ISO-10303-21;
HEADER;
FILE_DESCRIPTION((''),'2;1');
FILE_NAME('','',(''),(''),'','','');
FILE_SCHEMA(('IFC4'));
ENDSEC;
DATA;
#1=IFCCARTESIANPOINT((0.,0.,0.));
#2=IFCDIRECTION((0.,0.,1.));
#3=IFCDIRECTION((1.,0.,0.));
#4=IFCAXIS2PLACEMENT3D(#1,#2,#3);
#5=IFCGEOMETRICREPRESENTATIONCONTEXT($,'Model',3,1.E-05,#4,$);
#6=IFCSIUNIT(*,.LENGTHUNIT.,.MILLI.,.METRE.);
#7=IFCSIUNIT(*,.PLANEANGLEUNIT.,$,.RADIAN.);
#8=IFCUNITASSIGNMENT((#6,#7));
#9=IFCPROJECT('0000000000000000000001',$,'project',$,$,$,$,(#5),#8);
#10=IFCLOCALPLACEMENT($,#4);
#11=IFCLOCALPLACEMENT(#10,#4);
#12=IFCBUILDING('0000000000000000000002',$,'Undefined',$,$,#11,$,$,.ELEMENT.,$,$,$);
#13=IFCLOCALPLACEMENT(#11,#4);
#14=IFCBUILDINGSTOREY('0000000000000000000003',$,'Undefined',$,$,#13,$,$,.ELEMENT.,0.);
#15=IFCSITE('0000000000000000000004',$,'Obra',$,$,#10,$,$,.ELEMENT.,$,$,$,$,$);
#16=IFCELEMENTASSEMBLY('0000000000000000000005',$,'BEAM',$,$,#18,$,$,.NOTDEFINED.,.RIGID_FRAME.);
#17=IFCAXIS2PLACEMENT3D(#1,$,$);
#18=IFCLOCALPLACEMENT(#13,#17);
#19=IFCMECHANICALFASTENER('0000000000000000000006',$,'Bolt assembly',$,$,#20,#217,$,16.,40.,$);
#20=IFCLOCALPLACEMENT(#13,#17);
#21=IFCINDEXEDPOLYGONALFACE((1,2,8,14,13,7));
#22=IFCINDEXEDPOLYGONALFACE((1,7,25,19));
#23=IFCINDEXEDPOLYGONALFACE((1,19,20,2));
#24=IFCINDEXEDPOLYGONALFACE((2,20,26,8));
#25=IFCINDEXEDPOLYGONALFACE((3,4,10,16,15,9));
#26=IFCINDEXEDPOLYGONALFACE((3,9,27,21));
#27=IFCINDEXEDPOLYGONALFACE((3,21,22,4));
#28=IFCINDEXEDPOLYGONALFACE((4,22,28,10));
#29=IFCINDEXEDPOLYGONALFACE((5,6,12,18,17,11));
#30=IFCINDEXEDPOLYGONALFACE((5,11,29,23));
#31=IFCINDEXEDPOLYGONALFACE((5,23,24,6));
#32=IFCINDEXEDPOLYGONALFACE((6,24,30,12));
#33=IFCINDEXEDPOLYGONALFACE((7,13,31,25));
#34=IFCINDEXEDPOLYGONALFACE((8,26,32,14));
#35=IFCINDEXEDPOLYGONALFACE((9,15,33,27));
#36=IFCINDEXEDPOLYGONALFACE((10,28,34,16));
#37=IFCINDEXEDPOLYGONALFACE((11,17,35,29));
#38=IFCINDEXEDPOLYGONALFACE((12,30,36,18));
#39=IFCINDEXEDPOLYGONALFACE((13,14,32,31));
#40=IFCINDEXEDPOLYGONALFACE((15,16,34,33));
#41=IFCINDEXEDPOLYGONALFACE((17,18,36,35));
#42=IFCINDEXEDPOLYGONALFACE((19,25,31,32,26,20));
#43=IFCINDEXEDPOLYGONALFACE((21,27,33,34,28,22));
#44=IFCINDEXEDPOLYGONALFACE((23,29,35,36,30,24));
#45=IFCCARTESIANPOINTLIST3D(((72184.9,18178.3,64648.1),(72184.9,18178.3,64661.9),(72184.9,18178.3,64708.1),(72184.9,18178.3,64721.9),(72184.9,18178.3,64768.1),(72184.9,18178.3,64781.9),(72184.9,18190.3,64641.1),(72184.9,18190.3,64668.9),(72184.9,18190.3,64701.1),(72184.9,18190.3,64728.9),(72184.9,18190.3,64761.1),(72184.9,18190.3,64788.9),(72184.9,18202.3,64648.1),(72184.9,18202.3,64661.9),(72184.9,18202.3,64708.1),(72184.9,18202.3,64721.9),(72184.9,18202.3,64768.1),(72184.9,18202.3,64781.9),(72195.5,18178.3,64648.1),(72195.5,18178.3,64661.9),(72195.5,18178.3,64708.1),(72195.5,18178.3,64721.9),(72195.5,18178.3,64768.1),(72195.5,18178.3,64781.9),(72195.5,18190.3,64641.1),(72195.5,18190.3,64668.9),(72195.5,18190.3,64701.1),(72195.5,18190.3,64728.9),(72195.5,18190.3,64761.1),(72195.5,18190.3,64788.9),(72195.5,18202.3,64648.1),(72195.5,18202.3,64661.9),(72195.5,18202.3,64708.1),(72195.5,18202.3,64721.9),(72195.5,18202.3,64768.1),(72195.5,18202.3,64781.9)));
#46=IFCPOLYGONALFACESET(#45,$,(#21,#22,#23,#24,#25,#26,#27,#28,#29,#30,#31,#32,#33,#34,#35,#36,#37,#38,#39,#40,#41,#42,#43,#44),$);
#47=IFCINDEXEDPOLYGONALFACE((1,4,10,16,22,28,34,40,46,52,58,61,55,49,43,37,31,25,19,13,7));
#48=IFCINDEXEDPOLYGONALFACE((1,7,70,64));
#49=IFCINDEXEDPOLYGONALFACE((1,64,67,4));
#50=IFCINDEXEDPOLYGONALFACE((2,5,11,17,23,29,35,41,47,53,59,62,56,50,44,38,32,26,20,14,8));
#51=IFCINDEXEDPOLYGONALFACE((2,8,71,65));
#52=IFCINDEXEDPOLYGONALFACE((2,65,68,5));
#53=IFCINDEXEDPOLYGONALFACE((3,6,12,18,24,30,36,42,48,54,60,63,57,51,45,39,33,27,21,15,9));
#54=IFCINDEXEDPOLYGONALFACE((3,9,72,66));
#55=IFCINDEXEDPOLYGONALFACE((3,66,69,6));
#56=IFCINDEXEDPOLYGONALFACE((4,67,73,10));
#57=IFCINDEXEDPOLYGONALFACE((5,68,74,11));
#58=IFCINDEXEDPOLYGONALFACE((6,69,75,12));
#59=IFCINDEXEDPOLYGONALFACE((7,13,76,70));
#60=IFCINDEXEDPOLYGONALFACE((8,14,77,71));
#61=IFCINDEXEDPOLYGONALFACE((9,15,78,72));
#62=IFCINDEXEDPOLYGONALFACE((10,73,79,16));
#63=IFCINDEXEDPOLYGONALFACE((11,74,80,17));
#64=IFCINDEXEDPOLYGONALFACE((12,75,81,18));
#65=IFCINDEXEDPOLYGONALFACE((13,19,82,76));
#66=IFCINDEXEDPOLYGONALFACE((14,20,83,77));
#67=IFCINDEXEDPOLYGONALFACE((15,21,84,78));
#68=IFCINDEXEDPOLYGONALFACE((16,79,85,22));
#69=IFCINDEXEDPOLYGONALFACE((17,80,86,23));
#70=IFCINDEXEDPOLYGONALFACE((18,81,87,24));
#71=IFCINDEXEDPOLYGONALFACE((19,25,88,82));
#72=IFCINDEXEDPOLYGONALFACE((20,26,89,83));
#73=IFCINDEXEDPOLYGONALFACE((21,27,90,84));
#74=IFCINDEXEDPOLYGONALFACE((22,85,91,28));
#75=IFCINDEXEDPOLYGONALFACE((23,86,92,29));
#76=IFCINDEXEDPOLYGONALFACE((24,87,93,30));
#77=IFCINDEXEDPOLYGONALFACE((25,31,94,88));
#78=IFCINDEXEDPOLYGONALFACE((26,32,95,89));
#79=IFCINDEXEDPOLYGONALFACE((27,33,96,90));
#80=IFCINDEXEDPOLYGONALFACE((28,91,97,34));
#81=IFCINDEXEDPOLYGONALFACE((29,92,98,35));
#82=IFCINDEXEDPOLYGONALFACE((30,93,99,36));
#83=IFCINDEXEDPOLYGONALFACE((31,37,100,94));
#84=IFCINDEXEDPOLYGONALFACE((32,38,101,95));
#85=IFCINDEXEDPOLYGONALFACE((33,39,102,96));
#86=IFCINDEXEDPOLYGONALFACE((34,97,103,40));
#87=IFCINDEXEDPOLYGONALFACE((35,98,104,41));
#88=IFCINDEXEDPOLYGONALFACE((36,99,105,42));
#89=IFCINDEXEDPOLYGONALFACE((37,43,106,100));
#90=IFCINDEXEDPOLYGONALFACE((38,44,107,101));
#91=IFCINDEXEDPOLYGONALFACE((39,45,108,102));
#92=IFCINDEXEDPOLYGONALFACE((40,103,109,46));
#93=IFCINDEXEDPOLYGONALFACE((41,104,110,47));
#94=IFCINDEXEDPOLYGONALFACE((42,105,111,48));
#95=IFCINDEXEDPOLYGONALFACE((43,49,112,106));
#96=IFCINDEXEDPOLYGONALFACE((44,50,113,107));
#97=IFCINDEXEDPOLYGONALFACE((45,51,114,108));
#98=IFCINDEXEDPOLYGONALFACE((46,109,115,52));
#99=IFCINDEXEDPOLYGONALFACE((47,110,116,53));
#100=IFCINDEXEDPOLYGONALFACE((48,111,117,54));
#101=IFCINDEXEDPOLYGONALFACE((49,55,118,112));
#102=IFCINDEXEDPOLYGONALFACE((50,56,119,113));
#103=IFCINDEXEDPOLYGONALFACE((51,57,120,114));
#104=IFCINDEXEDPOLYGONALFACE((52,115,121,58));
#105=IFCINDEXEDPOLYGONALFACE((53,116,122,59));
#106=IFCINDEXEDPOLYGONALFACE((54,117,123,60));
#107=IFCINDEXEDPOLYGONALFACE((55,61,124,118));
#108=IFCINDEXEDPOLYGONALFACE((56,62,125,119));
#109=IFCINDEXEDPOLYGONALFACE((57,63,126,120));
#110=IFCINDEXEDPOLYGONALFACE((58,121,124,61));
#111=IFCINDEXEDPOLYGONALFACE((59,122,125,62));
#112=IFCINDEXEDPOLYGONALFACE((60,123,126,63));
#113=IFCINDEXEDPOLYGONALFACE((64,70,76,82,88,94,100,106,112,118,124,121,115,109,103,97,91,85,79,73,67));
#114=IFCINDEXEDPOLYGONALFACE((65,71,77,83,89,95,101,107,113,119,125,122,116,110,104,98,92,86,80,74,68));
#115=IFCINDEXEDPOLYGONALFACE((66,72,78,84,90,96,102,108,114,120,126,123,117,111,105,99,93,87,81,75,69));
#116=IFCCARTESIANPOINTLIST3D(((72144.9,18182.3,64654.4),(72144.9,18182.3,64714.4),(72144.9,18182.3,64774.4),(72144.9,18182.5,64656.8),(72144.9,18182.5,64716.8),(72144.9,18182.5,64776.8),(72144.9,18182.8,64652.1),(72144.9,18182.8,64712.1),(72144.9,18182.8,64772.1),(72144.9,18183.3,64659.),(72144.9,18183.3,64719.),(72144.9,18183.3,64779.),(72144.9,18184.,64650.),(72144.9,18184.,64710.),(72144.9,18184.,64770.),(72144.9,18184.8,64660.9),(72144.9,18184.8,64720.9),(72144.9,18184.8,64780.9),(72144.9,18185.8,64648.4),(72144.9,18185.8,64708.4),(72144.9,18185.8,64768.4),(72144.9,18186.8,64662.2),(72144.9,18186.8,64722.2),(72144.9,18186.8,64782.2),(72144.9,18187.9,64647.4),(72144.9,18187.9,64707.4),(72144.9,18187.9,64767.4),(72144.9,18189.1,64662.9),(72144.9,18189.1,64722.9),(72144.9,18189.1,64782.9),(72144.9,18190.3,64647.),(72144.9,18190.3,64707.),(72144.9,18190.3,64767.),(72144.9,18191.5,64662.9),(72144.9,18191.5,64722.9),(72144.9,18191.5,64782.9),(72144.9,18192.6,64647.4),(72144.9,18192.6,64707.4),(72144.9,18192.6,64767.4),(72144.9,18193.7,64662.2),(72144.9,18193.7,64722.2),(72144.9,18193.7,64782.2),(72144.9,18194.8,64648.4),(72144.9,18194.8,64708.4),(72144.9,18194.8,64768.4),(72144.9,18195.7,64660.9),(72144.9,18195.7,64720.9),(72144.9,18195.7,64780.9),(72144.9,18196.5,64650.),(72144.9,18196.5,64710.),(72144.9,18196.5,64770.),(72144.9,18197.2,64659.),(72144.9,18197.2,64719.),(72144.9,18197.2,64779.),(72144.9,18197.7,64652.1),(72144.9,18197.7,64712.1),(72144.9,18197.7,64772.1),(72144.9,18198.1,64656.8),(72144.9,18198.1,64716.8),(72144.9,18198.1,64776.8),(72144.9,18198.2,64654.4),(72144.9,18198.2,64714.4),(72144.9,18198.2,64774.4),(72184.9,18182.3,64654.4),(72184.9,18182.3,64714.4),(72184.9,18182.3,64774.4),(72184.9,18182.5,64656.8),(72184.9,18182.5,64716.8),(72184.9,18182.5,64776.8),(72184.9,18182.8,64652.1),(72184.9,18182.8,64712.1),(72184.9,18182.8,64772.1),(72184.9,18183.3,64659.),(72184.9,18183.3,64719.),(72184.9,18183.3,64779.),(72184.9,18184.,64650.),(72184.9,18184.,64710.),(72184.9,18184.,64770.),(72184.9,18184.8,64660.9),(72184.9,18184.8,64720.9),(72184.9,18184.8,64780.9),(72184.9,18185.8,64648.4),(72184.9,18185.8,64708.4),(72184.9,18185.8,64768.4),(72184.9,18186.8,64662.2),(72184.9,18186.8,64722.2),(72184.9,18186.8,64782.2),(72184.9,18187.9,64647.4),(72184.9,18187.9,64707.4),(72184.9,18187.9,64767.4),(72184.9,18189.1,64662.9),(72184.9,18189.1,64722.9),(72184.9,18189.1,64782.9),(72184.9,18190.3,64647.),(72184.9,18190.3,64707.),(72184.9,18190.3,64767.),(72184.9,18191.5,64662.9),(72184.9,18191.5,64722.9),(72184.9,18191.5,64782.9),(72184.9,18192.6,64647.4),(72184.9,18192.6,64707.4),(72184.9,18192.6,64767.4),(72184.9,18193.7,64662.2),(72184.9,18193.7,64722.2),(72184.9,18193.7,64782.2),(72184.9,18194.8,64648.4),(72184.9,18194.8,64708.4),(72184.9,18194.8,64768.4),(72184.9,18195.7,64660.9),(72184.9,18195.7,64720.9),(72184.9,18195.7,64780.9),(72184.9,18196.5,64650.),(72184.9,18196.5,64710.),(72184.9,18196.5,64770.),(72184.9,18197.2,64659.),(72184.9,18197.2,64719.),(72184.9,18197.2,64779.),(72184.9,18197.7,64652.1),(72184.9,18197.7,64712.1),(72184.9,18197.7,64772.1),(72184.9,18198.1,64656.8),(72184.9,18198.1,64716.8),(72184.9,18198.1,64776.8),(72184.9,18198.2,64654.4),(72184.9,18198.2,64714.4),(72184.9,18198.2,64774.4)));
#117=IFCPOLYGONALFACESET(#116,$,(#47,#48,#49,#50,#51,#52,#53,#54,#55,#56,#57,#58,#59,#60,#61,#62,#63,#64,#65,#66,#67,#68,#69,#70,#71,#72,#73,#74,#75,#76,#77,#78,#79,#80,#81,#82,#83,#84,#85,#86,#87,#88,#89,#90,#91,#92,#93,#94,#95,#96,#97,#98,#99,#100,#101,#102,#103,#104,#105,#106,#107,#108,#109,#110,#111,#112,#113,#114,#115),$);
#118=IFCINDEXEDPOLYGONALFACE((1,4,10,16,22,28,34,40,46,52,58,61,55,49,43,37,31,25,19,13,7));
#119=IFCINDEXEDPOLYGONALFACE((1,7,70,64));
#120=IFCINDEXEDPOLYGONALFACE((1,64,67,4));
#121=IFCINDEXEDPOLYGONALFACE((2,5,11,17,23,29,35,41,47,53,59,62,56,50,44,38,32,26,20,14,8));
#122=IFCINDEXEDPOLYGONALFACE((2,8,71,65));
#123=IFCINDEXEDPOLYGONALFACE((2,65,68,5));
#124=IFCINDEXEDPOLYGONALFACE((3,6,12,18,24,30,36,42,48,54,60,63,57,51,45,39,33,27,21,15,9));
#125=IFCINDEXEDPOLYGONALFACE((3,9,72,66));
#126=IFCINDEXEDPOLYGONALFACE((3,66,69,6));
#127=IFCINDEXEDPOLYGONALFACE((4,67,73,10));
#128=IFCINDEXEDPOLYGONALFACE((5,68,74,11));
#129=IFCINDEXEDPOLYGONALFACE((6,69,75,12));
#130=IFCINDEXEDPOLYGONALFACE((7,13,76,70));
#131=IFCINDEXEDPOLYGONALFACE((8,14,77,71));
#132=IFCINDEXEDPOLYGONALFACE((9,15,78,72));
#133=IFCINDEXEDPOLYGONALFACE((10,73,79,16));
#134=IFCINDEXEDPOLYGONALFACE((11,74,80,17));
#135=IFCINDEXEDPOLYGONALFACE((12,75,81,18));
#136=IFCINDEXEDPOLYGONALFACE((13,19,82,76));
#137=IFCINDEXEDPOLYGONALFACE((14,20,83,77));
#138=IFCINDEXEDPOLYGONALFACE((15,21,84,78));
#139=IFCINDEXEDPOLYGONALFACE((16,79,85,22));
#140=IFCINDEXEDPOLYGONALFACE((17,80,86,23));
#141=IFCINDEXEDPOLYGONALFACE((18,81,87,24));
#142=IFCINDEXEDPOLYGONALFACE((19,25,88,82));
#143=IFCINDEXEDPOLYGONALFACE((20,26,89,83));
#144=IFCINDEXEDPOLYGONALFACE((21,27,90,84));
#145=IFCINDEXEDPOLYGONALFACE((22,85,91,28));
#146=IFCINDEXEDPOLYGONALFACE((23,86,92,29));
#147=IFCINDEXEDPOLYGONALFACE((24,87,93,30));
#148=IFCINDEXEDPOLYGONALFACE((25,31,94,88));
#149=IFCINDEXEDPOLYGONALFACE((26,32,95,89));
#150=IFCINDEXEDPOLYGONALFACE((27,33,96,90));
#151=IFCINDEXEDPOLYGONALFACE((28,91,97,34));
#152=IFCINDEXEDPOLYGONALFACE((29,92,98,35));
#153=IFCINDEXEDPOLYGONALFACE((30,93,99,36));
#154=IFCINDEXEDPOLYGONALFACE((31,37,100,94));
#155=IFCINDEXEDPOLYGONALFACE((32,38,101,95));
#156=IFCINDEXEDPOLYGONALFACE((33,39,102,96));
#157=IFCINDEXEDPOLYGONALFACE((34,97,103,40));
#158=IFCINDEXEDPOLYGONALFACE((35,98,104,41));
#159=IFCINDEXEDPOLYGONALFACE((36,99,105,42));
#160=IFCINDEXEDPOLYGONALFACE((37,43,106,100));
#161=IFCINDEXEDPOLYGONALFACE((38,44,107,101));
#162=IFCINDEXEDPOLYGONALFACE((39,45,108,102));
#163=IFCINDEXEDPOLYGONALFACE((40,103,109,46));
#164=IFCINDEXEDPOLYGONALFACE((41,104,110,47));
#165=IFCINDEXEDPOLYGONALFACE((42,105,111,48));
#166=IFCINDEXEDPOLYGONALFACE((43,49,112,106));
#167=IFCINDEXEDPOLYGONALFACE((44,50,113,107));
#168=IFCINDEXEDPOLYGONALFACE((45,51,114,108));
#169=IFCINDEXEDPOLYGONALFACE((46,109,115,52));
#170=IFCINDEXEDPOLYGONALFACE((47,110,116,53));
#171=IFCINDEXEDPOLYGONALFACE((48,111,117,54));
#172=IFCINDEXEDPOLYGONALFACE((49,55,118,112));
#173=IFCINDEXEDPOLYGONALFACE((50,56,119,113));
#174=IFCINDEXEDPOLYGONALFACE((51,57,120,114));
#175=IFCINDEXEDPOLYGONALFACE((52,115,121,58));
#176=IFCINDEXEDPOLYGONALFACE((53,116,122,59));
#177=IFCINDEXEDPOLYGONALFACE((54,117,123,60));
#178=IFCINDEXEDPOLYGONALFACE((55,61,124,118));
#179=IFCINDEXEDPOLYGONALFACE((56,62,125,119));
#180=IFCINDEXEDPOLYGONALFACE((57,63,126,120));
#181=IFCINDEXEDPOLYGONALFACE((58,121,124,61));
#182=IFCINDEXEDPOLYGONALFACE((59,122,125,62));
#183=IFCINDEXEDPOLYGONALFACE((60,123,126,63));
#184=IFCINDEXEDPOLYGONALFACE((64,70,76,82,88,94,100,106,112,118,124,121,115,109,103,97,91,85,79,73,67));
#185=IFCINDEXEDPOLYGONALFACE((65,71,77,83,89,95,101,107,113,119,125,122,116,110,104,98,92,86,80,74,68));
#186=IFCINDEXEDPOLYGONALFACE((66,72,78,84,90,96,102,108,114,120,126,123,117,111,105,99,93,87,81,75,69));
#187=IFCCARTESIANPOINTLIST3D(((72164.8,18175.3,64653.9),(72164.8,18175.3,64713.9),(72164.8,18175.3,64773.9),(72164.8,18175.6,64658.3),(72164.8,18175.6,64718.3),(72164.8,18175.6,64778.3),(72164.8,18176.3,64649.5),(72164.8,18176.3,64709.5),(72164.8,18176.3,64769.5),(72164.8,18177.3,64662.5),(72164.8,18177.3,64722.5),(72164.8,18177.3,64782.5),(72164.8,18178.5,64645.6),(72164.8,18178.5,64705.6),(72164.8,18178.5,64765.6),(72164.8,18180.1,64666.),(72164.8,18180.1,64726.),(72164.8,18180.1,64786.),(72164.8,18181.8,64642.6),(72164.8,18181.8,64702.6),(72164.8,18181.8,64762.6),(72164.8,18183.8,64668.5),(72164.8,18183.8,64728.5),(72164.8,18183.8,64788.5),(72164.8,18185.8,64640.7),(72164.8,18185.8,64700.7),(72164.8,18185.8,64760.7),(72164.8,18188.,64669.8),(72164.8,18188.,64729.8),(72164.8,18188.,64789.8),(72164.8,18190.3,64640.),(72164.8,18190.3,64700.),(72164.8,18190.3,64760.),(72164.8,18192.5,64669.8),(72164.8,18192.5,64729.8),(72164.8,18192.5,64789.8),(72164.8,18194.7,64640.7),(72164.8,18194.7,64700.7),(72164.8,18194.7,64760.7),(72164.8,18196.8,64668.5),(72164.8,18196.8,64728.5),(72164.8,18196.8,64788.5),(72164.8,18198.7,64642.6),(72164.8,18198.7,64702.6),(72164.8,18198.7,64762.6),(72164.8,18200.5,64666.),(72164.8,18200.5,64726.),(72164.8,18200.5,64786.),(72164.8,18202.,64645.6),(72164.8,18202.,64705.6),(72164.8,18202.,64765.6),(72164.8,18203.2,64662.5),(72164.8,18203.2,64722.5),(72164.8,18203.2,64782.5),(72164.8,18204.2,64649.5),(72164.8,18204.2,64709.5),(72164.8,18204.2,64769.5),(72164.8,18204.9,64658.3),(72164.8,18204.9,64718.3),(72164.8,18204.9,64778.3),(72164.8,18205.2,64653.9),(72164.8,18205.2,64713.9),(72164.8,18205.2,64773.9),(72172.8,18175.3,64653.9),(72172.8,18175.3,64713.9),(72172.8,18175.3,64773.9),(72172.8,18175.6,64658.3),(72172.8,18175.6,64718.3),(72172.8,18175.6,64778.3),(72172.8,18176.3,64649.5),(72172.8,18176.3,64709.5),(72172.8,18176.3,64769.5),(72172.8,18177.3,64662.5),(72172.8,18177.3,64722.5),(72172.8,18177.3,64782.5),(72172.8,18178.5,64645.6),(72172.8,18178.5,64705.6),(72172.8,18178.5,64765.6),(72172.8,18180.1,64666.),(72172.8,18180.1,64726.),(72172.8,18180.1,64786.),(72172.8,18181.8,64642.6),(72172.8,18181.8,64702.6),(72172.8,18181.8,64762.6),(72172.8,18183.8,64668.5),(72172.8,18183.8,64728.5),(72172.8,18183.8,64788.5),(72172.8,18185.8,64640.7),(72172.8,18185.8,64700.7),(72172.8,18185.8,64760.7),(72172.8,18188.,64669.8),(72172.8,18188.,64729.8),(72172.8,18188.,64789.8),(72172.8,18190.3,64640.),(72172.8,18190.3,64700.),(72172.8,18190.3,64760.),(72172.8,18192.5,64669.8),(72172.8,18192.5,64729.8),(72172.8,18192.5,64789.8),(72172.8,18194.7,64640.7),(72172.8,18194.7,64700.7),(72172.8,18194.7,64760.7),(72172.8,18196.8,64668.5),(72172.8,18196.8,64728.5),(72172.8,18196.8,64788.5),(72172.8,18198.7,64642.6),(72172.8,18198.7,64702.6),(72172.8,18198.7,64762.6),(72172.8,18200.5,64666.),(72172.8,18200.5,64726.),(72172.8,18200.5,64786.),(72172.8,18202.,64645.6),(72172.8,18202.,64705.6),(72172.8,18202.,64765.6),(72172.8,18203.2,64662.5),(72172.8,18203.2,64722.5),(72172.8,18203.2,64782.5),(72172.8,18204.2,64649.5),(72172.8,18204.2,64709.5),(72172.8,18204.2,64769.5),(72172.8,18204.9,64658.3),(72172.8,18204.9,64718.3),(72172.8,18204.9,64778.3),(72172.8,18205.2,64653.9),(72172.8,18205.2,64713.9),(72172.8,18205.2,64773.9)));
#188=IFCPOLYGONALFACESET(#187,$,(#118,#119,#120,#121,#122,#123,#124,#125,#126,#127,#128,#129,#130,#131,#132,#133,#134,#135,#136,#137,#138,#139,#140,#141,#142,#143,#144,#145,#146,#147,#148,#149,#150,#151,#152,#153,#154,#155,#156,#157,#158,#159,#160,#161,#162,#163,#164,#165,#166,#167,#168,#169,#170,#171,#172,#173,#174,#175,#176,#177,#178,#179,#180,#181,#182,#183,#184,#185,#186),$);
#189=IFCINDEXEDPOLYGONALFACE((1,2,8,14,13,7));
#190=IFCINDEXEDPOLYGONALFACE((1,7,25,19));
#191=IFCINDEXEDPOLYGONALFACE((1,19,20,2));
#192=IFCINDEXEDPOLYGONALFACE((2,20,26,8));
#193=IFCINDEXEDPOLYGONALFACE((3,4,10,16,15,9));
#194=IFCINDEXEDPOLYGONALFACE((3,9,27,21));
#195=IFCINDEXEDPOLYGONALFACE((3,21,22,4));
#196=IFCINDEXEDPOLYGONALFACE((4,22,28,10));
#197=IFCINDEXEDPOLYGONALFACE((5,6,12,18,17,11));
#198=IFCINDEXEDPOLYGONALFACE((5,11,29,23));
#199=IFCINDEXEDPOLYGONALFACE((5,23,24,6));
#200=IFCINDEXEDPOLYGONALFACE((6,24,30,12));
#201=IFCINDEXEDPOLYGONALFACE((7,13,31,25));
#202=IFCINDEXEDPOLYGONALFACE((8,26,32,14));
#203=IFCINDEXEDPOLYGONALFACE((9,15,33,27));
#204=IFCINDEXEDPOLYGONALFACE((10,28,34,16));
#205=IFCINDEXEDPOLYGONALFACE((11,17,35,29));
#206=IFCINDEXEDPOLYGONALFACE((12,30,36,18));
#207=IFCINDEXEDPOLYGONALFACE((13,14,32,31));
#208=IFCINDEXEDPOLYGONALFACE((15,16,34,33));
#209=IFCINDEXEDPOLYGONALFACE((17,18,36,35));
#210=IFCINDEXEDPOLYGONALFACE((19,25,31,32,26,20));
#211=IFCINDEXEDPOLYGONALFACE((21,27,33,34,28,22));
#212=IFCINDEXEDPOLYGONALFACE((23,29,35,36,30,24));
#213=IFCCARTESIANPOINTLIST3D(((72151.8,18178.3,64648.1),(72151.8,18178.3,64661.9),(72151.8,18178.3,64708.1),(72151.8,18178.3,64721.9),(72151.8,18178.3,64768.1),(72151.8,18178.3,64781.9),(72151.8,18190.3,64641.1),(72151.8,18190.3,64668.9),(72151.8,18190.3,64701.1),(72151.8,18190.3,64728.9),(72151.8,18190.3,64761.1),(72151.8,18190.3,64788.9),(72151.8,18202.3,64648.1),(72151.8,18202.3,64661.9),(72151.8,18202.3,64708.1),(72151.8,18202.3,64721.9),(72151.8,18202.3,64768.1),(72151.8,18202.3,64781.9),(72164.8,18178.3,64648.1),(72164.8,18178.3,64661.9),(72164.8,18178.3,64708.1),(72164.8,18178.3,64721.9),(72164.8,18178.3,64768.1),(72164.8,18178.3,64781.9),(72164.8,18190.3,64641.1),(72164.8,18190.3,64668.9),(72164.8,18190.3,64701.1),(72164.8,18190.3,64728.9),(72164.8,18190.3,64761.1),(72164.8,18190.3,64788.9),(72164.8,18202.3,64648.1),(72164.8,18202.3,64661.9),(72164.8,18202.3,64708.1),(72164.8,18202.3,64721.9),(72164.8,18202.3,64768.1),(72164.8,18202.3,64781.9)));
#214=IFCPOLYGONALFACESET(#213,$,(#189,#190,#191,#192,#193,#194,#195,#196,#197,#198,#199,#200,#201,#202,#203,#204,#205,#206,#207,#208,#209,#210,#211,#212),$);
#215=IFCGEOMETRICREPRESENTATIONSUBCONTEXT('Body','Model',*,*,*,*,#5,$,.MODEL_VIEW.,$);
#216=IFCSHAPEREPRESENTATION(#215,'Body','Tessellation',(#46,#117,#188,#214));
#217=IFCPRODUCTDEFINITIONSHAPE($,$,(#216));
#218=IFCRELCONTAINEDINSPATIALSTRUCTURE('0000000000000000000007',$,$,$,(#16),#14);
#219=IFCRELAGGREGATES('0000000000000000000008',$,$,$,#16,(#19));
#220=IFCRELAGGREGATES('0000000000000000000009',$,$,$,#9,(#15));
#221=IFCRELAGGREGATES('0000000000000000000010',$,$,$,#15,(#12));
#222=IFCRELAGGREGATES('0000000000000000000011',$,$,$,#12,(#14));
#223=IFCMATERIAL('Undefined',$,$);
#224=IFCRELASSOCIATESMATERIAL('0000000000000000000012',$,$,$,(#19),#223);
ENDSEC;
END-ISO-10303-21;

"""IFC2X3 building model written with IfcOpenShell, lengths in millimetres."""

from ifc_helpers import new_model, si_unit, frame, origin_with_axes, origin_2d_with_axis, place, context, subcontext, project, spatial, polyline, circle, outline, extrude, source, transform, mapped, material, element, aggregate, save


model = new_model("IFC2X3")

# Units and contexts
model_context = context("Model", 3, precision=1e-05, world=origin_with_axes())
body_context = subcontext(model_context, "Body", "Model", "MODEL_VIEW")
ifc_project = project(units=[si_unit("LENGTHUNIT", "METRE", prefix="MILLI"), si_unit("PLANEANGLEUNIT", "RADIAN")], contexts=[model_context])

# Site, building, storey
site_placement = place(None, origin_with_axes())
site = spatial("IfcSite", under=ifc_project, at=site_placement, Name="Obra", CompositionType="ELEMENT")
building_placement = place(site_placement, origin_with_axes())
building = spatial("IfcBuilding", under=site, at=building_placement, Name="Undefined", CompositionType="ELEMENT")
storey_placement = place(building_placement, origin_with_axes())
storey = spatial("IfcBuildingStorey", under=building, at=storey_placement, Name="Undefined", CompositionType="ELEMENT", Elevation=0.0)

# Element assembly, mechanical fastener
ifc_material_1 = material(Name="Undefined")
assembly_1_placement = place(storey_placement, origin_with_axes())
assembly_1 = element("IfcElementAssembly", 1, at=assembly_1_placement, inside=storey, Name="BEAM", AssemblyPlace="NOTDEFINED", PredefinedType="RIGID_FRAME")
shared_shape_1 = source(origin_with_axes(), body_context, "Body", "SweptSolid", [
    extrude(outline(polyline([(13.9, 0.0), (6.9, 12.0), (-6.9, 12.0), (-13.9, 0.0), (-6.9, -12.0), (6.9, -12.0), (13.9, 0.0)])), frame((0.0, -19.7, 0.0), z_axis=(0.0, 1.0, 0.0), x_axis=(1.0, 0.0, 0.0)), (0.0, 0.0, 1.0), 10.6),
    extrude(circle(Radius=8.0, at=origin_2d_with_axis()), frame((0.0, -9.1, 0.0), z_axis=(0.0, 1.0, 0.0), x_axis=(1.0, 0.0, 0.0)), (0.0, 0.0, 1.0), 40.0),
    extrude(circle(Radius=15.0, at=origin_2d_with_axis()), frame((0.0, 3.0, 0.0), z_axis=(0.0, 1.0, 0.0), x_axis=(1.0, 0.0, 0.0)), (0.0, 0.0, 1.0), 8.0),
    extrude(outline(polyline([(13.9, 0.0), (6.9, 12.0), (-6.9, 12.0), (-13.9, 0.0), (-6.9, -12.0), (6.9, -12.0), (13.9, 0.0)])), frame((0.0, 11.0, 0.0), z_axis=(0.0, 1.0, 0.0), x_axis=(1.0, 0.0, 0.0)), (0.0, 0.0, 1.0), 13.0),
])
mechanical_fastener_1_placement = place(assembly_1_placement, frame((72175.8, 18140.3, 64835.0), z_axis=(0.0, 1.0, 0.0), x_axis=(0.0, 0.0, -1.0)))
mechanical_fastener_1 = element("IfcMechanicalFastener", 2, at=mechanical_fastener_1_placement, material=ifc_material_1, Name="Bolt assembly", NominalDiameter=16.0, NominalLength=40.0, context=body_context, shape_type="MappedRepresentation", body=[
    mapped(shared_shape_1, transform((60.0, 0.0, 50.0))),
    mapped(shared_shape_1, transform((120.0, 0.0, 50.0))),
    mapped(shared_shape_1, transform((180.0, 0.0, 50.0))),
])

aggregate(assembly_1, [mechanical_fastener_1])

save(model, "model.ifc")
